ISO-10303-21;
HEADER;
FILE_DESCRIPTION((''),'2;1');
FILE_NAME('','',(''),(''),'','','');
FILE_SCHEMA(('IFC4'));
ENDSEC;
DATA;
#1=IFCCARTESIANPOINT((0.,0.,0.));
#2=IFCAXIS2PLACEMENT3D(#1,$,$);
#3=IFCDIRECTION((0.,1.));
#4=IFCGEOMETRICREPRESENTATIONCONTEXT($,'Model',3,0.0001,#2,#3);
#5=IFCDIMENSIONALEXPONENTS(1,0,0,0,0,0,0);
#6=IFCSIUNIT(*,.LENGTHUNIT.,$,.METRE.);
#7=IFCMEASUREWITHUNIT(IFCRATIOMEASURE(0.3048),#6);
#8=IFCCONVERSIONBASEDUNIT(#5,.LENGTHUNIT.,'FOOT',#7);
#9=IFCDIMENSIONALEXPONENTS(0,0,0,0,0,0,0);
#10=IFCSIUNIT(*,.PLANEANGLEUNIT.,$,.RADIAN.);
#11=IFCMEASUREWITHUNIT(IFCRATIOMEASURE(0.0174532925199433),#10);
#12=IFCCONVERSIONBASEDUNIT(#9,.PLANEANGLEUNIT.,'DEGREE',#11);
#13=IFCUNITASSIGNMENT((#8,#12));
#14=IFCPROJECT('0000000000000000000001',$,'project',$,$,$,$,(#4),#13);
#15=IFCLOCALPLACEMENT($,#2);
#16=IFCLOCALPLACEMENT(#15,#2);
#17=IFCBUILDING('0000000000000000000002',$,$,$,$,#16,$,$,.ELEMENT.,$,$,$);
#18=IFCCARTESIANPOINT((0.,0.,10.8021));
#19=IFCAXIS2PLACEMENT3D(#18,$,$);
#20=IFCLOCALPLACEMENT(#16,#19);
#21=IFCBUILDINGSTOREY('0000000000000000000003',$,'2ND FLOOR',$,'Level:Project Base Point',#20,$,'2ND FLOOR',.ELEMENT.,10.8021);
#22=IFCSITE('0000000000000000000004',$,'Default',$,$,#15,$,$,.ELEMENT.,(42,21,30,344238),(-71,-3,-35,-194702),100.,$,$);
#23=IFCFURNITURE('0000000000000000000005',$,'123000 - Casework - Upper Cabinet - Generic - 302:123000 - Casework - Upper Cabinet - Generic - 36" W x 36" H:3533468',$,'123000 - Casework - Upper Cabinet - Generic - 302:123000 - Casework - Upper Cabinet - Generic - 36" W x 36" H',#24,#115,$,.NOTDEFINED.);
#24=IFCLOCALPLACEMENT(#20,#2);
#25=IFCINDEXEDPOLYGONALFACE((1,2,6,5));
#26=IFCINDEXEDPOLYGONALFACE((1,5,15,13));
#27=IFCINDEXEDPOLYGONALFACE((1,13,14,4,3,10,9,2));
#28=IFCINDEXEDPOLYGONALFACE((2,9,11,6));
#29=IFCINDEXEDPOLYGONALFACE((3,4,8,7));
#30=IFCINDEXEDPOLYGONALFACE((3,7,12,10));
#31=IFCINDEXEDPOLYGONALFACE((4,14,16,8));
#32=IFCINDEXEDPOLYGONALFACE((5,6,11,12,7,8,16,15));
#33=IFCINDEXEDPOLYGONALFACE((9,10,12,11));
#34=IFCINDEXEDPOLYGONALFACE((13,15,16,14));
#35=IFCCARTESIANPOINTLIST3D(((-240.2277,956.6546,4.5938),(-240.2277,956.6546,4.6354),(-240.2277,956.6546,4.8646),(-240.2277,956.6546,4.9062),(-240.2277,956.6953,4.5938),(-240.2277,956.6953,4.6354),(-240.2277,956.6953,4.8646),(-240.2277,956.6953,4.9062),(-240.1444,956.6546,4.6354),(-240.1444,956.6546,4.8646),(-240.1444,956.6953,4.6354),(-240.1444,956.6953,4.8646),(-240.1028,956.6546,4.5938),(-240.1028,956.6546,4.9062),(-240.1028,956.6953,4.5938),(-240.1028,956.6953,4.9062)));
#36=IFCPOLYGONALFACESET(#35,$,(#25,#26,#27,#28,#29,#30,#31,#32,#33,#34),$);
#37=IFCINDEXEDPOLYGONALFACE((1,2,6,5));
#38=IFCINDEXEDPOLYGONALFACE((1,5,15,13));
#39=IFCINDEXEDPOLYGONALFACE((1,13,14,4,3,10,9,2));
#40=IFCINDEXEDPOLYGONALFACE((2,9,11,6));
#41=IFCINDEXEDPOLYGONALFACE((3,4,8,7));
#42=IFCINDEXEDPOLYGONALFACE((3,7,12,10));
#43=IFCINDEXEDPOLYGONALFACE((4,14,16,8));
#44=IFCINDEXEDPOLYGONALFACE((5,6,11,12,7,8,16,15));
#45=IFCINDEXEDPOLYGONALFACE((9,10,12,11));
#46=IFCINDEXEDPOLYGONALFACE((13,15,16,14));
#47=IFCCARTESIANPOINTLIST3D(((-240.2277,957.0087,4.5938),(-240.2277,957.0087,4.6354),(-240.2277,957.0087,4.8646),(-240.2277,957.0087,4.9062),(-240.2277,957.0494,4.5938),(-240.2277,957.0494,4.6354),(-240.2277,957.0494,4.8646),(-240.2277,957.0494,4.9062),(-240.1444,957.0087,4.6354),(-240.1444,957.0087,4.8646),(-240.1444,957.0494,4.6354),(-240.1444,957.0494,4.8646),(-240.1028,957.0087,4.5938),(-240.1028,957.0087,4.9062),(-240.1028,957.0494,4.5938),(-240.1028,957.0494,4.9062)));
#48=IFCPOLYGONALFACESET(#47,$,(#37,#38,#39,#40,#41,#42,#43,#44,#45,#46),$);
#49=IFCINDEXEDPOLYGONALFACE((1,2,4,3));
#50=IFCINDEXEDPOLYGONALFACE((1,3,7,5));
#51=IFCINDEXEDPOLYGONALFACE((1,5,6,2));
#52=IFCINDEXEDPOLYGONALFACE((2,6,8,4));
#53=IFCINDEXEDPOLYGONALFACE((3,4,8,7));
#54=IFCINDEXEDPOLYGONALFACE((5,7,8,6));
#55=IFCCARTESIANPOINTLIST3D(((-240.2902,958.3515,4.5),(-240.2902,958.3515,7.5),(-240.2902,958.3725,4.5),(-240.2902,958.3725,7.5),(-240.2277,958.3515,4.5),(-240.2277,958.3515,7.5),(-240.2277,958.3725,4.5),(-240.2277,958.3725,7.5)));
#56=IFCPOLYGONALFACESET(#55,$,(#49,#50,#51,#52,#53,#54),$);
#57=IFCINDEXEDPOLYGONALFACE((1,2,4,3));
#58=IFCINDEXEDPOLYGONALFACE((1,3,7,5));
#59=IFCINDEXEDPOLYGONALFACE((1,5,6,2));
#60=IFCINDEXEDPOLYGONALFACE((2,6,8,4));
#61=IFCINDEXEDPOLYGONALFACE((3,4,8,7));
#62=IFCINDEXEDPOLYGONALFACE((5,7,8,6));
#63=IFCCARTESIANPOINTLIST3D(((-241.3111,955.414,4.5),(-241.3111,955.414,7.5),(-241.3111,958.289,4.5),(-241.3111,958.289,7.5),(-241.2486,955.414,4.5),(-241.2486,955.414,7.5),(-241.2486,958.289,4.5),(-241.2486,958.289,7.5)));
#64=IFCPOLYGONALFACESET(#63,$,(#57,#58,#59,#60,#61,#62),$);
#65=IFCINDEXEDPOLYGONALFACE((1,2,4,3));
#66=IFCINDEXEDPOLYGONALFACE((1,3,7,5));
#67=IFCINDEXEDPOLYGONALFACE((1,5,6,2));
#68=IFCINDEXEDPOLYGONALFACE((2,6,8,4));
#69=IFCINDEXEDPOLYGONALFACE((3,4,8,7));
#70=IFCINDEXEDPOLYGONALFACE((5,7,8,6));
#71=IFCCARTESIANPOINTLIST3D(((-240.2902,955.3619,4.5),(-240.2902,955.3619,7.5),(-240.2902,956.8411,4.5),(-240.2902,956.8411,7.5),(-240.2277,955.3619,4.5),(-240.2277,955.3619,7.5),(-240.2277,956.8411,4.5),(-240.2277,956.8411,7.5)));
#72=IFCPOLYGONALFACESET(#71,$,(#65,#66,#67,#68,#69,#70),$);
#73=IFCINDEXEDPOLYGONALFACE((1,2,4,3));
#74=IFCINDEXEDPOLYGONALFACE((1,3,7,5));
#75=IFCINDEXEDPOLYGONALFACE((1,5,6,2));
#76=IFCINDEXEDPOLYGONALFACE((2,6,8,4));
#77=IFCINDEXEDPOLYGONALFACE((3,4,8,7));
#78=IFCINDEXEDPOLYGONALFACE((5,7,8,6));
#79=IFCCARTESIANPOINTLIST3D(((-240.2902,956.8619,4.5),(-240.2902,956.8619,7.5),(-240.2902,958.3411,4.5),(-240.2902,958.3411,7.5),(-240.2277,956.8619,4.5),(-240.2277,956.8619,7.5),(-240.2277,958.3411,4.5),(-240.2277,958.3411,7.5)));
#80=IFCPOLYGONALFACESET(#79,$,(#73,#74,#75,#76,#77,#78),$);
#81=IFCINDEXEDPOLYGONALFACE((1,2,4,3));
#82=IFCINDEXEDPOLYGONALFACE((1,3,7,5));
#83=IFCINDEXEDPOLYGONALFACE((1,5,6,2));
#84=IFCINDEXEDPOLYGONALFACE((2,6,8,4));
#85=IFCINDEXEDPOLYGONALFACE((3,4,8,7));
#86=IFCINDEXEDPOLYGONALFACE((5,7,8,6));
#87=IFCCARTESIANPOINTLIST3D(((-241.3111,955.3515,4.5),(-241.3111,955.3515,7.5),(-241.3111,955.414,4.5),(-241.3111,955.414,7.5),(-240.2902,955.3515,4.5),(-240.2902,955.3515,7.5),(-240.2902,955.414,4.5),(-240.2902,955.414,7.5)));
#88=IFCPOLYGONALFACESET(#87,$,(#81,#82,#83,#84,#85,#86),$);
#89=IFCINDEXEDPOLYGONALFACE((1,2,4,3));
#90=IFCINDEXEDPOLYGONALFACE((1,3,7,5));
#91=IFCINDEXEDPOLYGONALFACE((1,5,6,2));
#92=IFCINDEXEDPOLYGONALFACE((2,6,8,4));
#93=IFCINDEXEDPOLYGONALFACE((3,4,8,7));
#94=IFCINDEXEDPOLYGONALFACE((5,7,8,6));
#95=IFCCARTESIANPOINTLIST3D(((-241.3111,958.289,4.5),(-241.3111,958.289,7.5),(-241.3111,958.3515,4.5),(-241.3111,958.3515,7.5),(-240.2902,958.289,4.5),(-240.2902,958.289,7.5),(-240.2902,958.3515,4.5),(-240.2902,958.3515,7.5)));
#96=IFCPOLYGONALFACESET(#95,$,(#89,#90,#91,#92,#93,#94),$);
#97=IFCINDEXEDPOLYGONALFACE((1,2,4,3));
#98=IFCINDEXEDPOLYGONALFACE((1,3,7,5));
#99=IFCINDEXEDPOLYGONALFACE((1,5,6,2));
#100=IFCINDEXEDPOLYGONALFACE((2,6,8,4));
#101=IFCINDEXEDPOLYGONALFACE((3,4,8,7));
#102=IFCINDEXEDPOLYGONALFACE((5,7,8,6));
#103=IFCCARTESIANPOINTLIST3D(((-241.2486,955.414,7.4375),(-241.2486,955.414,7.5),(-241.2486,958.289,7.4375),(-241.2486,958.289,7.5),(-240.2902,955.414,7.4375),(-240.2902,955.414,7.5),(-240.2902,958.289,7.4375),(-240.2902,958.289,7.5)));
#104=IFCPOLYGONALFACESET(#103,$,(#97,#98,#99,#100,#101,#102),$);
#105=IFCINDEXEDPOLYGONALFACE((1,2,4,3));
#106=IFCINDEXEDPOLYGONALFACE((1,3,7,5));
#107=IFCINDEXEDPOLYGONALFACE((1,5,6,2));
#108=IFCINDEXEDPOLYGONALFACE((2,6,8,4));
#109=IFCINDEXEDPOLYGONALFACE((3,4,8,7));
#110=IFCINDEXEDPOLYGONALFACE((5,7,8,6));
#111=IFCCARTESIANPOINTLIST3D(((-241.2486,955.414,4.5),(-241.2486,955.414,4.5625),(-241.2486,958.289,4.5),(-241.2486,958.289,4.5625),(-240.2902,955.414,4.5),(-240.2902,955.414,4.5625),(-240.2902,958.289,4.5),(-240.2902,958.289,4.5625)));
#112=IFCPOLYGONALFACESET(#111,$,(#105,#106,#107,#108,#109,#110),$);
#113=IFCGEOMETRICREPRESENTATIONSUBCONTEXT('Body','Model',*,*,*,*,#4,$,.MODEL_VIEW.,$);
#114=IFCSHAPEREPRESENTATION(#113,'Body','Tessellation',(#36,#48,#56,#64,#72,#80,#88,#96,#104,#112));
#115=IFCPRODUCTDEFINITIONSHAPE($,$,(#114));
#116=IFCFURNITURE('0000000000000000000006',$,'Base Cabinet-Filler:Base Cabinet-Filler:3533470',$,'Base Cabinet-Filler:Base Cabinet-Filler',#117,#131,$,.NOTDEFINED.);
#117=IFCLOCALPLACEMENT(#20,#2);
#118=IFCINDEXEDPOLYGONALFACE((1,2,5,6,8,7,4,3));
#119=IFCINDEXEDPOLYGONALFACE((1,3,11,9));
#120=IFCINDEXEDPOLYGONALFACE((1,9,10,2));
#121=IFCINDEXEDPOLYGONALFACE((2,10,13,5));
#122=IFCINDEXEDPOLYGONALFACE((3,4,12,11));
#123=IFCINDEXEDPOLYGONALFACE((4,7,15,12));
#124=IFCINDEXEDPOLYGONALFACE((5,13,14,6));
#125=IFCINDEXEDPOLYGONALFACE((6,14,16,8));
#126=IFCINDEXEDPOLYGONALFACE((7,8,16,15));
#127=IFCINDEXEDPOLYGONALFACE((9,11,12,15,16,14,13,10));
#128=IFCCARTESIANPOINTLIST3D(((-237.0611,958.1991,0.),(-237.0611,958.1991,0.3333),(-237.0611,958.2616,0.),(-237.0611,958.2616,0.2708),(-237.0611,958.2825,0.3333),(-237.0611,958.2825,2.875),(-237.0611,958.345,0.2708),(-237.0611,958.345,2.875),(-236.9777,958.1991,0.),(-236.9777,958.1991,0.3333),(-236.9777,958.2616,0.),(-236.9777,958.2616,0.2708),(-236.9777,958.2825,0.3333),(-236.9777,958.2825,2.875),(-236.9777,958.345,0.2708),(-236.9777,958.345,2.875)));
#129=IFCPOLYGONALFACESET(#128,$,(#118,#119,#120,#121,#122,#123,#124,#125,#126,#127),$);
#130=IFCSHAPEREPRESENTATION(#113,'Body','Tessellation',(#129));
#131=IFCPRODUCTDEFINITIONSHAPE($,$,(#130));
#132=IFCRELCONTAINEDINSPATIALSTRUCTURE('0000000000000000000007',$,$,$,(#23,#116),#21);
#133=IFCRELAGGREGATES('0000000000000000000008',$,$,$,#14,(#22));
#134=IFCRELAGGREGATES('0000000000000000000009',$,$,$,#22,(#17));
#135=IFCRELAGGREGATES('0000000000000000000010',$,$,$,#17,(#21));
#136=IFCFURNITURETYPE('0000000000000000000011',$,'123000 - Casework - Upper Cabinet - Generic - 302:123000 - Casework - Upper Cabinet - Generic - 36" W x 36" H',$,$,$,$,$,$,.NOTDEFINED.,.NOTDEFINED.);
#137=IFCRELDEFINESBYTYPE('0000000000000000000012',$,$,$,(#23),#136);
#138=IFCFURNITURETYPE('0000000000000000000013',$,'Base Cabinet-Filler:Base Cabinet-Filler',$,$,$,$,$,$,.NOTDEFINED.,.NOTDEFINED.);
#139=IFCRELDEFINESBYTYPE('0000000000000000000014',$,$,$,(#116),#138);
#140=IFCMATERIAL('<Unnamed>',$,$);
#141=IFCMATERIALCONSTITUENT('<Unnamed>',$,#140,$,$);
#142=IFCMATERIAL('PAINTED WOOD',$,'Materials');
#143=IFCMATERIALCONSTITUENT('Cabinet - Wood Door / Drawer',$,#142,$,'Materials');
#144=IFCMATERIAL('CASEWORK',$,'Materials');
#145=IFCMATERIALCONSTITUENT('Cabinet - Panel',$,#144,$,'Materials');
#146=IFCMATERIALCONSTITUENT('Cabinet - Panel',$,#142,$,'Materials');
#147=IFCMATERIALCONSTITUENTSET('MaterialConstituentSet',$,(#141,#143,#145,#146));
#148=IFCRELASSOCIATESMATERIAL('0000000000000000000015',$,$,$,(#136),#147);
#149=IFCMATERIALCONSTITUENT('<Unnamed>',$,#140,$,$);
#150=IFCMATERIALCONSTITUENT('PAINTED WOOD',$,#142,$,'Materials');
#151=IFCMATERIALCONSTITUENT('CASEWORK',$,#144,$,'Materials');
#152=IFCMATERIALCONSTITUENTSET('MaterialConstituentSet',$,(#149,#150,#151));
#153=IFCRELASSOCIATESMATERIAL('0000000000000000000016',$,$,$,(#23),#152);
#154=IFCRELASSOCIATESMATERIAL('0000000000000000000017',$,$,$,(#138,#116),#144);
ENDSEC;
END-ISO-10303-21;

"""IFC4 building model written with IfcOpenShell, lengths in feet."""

from ifc_helpers import new_model, entity, si_unit, converted_unit, direction, frame, frame_2d, origin, origin_2d_with_axis, place, context, subcontext, project, spatial, polyline, rectangle, outline, extrude, source, transform, mapped, material, constituent, constituent_set, type_object, type_shapes, element, save


model = new_model("IFC4")

# Units and contexts
model_context = context("Model", 3, precision=0.0001, world=origin(), true_north=direction((0.0, 1.0)))
body_context = subcontext(model_context, "Body", "Model", "MODEL_VIEW")
ifc_project = project(units=[converted_unit("LENGTHUNIT", "FOOT", entity("IfcRatioMeasure", 0.3048), si_unit("LENGTHUNIT", "METRE"), dimensions=[1, 0, 0, 0, 0, 0, 0]), converted_unit("PLANEANGLEUNIT", "DEGREE", entity("IfcRatioMeasure", 0.0174532925199433), si_unit("PLANEANGLEUNIT", "RADIAN"), dimensions=[0, 0, 0, 0, 0, 0, 0])], contexts=[model_context])

# Site, building, storey
site_placement = place(None, origin())
site = spatial("IfcSite", under=ifc_project, at=site_placement, Name="Default", CompositionType="ELEMENT", RefLatitude=(42, 21, 30, 344238), RefLongitude=(-71, -3, -35, -194702), RefElevation=100.0)
building_placement = place(site_placement, origin())
building = spatial("IfcBuilding", under=site, at=building_placement, CompositionType="ELEMENT")
storey_placement = place(building_placement, frame((0.0, 0.0, 10.8021)))
storey = spatial("IfcBuildingStorey", under=building, at=storey_placement, Name="2ND FLOOR", ObjectType="Level:Project Base Point", LongName="2ND FLOOR", CompositionType="ELEMENT", Elevation=10.8021)

# Shared definitions
ifc_material_1 = material(Name="PAINTED WOOD", Category="Materials")
ifc_material_2 = material(Name="CASEWORK", Category="Materials")

# Furniture
ifc_material_3 = material(Name="<Unnamed>")
ifc_constituent_1 = constituent(ifc_material_3, Name="<Unnamed>")
ifc_constituent_2 = constituent(ifc_material_1, Name="PAINTED WOOD", Category="Materials")
ifc_constituent_3 = constituent(ifc_material_2, Name="CASEWORK", Category="Materials")
ifc_constituent_set_1 = constituent_set(constituents=[ifc_constituent_1, ifc_constituent_2, ifc_constituent_3], Name="MaterialConstituentSet")
ifc_constituent_4 = constituent(ifc_material_3, Name="<Unnamed>")
ifc_constituent_5 = constituent(ifc_material_1, Name="Cabinet - Wood Door / Drawer", Category="Materials")
ifc_constituent_6 = constituent(ifc_material_2, Name="Cabinet - Panel", Category="Materials")
ifc_constituent_7 = constituent(ifc_material_1, Name="Cabinet - Panel", Category="Materials")
ifc_constituent_set_2 = constituent_set(constituents=[ifc_constituent_4, ifc_constituent_5, ifc_constituent_6, ifc_constituent_7], Name="MaterialConstituentSet")
furniture_type_1 = type_object("IfcFurnitureType", Name="123000 - Casework - Upper Cabinet - Generic - 302:123000 - Casework - Upper Cabinet - Generic - 36\" W x 36\" H", AssemblyPlace="NOTDEFINED", PredefinedType="NOTDEFINED", material=ifc_constituent_set_2)
shared_shape_1 = source(origin(), body_context, "Body", "SweptSolid", [
    extrude(outline(polyline([(0.1146, -0.0521), (0.1562, -0.0521), (0.1562, 0.0729), (-0.1562, 0.0729), (-0.1562, -0.0521), (-0.1146, -0.0521), (-0.1146, 0.0313), (0.1146, 0.0313), (0.1146, -0.0521)])), frame((1.303, 0.0729, 0.25), z_axis=(1.0, 0.0, 0.0), x_axis=(0.0, 0.0, 1.0)), (0.0, 0.0, 1.0), 0.0407),
    extrude(outline(polyline([(0.1146, -0.0521), (0.1562, -0.0521), (0.1562, 0.0729), (-0.1562, 0.0729), (-0.1562, -0.0521), (-0.1146, -0.0521), (-0.1146, 0.0313), (0.1146, 0.0313), (0.1146, -0.0521)])), frame((1.6572, 0.0729, 0.25), z_axis=(1.0, 0.0, 0.0), x_axis=(0.0, 0.0, 1.0)), (0.0, 0.0, 1.0), 0.0407),
    extrude(rectangle(XDim=0.0625, YDim=0.021, at=frame_2d((0.0, 0.0), x_axis=(1.0, 0.0))), frame((3.0105, 0.1562, 0.0), z_axis=(0.0, 0.0, 1.0), x_axis=(0.0, -1.0, 0.0)), (0.0, 0.0, 1.0), 3.0),
    extrude(rectangle(XDim=0.0625, YDim=2.875, at=origin_2d_with_axis()), frame((1.5, 1.177, 0.0), z_axis=(0.0, 0.0, 1.0), x_axis=(0.0, 1.0, 0.0)), (0.0, 0.0, 1.0), 3.0),
    extrude(rectangle(XDim=0.0625, YDim=1.4792, at=frame_2d((0.0, 0.0), x_axis=(1.0, 0.0))), frame((0.75, 0.1562, 0.0), z_axis=(0.0, 0.0, 1.0), x_axis=(0.0, -1.0, 0.0)), (0.0, 0.0, 1.0), 3.0),
    extrude(rectangle(XDim=0.0625, YDim=1.4792, at=origin_2d_with_axis()), frame((2.25, 0.1562, 0.0), z_axis=(0.0, 0.0, 1.0), x_axis=(0.0, -1.0, 0.0)), (0.0, 0.0, 1.0), 3.0),
    extrude(rectangle(XDim=0.0625, YDim=1.0208, at=origin_2d_with_axis()), frame((0.0312, 0.6979, 0.0), z_axis=(0.0, 0.0, 1.0), x_axis=(-1.0, 0.0, 0.0)), (0.0, 0.0, 1.0), 3.0),
    extrude(rectangle(XDim=0.0625, YDim=1.0208, at=origin_2d_with_axis()), frame((2.9688, 0.6979, 0.0), z_axis=(0.0, 0.0, 1.0), x_axis=(-1.0, 0.0, 0.0)), (0.0, 0.0, 1.0), 3.0),
    extrude(rectangle(XDim=2.875, YDim=0.9583, at=frame_2d((0.0, 0.0), x_axis=(1.0, 0.0))), frame((1.5, 0.6666, 2.9375), z_axis=(0.0, 0.0, 1.0), x_axis=(-1.0, 0.0, 0.0)), (0.0, 0.0, 1.0), 0.0625),
    extrude(rectangle(XDim=2.875, YDim=0.9583, at=frame_2d((0.0, 0.0), x_axis=(1.0, 0.0))), frame((1.5, 0.6666, 0.0), z_axis=(0.0, 0.0, 1.0), x_axis=(-1.0, 0.0, 0.0)), (0.0, 0.0, 1.0), 0.0625),
])
type_shapes(furniture_type_1, [shared_shape_1])
furniture_1_placement = place(storey_placement, frame((-240.1028, 955.3515, 4.5), z_axis=(0.0, 0.0, 1.0), x_axis=(0.0, 1.0, 0.0)))
element("IfcFurniture", 1, at=furniture_1_placement, inside=storey, type_object=furniture_type_1, material=ifc_constituent_set_1, Name="123000 - Casework - Upper Cabinet - Generic - 302:123000 - Casework - Upper Cabinet - Generic - 36\" W x 36\" H:3533468", ObjectType="123000 - Casework - Upper Cabinet - Generic - 302:123000 - Casework - Upper Cabinet - Generic - 36\" W x 36\" H", PredefinedType="NOTDEFINED", context=body_context, shape_type="MappedRepresentation", body=[
    mapped(shared_shape_1, transform((0.0, 0.0, 0.0), scale=1.0)),
])
furniture_type_2 = type_object("IfcFurnitureType", Name="Base Cabinet-Filler:Base Cabinet-Filler", AssemblyPlace="NOTDEFINED", PredefinedType="NOTDEFINED", material=ifc_material_2)
shared_shape_2 = source(origin(), body_context, "Body", "SweptSolid", [
    extrude(outline(polyline([(-0.0729, 0.599), (-0.0729, -2.0052), (-0.0104, -2.0052), (-0.0104, 0.5365), (0.0729, 0.5365), (0.0729, 0.8698), (0.0104, 0.8698), (0.0104, 0.599), (-0.0729, 0.599)])), frame((0.0, 0.0729, 0.8698), z_axis=(-1.0, 0.0, 0.0), x_axis=(0.0, 1.0, 0.0)), (0.0, 0.0, -1.0), 0.0833),
])
type_shapes(furniture_type_2, [shared_shape_2])
furniture_2_placement = place(storey_placement, frame((-236.9777, 958.345, 0.0), z_axis=(0.0, 0.0, 1.0), x_axis=(-1.0, 0.0, 0.0)))
element("IfcFurniture", 2, at=furniture_2_placement, inside=storey, type_object=furniture_type_2, material=ifc_material_2, Name="Base Cabinet-Filler:Base Cabinet-Filler:3533470", ObjectType="Base Cabinet-Filler:Base Cabinet-Filler", PredefinedType="NOTDEFINED", context=body_context, shape_type="MappedRepresentation", body=[
    mapped(shared_shape_2, transform((0.0, 0.0, 0.0), scale=1.0)),
])

save(model, "model.ifc")
